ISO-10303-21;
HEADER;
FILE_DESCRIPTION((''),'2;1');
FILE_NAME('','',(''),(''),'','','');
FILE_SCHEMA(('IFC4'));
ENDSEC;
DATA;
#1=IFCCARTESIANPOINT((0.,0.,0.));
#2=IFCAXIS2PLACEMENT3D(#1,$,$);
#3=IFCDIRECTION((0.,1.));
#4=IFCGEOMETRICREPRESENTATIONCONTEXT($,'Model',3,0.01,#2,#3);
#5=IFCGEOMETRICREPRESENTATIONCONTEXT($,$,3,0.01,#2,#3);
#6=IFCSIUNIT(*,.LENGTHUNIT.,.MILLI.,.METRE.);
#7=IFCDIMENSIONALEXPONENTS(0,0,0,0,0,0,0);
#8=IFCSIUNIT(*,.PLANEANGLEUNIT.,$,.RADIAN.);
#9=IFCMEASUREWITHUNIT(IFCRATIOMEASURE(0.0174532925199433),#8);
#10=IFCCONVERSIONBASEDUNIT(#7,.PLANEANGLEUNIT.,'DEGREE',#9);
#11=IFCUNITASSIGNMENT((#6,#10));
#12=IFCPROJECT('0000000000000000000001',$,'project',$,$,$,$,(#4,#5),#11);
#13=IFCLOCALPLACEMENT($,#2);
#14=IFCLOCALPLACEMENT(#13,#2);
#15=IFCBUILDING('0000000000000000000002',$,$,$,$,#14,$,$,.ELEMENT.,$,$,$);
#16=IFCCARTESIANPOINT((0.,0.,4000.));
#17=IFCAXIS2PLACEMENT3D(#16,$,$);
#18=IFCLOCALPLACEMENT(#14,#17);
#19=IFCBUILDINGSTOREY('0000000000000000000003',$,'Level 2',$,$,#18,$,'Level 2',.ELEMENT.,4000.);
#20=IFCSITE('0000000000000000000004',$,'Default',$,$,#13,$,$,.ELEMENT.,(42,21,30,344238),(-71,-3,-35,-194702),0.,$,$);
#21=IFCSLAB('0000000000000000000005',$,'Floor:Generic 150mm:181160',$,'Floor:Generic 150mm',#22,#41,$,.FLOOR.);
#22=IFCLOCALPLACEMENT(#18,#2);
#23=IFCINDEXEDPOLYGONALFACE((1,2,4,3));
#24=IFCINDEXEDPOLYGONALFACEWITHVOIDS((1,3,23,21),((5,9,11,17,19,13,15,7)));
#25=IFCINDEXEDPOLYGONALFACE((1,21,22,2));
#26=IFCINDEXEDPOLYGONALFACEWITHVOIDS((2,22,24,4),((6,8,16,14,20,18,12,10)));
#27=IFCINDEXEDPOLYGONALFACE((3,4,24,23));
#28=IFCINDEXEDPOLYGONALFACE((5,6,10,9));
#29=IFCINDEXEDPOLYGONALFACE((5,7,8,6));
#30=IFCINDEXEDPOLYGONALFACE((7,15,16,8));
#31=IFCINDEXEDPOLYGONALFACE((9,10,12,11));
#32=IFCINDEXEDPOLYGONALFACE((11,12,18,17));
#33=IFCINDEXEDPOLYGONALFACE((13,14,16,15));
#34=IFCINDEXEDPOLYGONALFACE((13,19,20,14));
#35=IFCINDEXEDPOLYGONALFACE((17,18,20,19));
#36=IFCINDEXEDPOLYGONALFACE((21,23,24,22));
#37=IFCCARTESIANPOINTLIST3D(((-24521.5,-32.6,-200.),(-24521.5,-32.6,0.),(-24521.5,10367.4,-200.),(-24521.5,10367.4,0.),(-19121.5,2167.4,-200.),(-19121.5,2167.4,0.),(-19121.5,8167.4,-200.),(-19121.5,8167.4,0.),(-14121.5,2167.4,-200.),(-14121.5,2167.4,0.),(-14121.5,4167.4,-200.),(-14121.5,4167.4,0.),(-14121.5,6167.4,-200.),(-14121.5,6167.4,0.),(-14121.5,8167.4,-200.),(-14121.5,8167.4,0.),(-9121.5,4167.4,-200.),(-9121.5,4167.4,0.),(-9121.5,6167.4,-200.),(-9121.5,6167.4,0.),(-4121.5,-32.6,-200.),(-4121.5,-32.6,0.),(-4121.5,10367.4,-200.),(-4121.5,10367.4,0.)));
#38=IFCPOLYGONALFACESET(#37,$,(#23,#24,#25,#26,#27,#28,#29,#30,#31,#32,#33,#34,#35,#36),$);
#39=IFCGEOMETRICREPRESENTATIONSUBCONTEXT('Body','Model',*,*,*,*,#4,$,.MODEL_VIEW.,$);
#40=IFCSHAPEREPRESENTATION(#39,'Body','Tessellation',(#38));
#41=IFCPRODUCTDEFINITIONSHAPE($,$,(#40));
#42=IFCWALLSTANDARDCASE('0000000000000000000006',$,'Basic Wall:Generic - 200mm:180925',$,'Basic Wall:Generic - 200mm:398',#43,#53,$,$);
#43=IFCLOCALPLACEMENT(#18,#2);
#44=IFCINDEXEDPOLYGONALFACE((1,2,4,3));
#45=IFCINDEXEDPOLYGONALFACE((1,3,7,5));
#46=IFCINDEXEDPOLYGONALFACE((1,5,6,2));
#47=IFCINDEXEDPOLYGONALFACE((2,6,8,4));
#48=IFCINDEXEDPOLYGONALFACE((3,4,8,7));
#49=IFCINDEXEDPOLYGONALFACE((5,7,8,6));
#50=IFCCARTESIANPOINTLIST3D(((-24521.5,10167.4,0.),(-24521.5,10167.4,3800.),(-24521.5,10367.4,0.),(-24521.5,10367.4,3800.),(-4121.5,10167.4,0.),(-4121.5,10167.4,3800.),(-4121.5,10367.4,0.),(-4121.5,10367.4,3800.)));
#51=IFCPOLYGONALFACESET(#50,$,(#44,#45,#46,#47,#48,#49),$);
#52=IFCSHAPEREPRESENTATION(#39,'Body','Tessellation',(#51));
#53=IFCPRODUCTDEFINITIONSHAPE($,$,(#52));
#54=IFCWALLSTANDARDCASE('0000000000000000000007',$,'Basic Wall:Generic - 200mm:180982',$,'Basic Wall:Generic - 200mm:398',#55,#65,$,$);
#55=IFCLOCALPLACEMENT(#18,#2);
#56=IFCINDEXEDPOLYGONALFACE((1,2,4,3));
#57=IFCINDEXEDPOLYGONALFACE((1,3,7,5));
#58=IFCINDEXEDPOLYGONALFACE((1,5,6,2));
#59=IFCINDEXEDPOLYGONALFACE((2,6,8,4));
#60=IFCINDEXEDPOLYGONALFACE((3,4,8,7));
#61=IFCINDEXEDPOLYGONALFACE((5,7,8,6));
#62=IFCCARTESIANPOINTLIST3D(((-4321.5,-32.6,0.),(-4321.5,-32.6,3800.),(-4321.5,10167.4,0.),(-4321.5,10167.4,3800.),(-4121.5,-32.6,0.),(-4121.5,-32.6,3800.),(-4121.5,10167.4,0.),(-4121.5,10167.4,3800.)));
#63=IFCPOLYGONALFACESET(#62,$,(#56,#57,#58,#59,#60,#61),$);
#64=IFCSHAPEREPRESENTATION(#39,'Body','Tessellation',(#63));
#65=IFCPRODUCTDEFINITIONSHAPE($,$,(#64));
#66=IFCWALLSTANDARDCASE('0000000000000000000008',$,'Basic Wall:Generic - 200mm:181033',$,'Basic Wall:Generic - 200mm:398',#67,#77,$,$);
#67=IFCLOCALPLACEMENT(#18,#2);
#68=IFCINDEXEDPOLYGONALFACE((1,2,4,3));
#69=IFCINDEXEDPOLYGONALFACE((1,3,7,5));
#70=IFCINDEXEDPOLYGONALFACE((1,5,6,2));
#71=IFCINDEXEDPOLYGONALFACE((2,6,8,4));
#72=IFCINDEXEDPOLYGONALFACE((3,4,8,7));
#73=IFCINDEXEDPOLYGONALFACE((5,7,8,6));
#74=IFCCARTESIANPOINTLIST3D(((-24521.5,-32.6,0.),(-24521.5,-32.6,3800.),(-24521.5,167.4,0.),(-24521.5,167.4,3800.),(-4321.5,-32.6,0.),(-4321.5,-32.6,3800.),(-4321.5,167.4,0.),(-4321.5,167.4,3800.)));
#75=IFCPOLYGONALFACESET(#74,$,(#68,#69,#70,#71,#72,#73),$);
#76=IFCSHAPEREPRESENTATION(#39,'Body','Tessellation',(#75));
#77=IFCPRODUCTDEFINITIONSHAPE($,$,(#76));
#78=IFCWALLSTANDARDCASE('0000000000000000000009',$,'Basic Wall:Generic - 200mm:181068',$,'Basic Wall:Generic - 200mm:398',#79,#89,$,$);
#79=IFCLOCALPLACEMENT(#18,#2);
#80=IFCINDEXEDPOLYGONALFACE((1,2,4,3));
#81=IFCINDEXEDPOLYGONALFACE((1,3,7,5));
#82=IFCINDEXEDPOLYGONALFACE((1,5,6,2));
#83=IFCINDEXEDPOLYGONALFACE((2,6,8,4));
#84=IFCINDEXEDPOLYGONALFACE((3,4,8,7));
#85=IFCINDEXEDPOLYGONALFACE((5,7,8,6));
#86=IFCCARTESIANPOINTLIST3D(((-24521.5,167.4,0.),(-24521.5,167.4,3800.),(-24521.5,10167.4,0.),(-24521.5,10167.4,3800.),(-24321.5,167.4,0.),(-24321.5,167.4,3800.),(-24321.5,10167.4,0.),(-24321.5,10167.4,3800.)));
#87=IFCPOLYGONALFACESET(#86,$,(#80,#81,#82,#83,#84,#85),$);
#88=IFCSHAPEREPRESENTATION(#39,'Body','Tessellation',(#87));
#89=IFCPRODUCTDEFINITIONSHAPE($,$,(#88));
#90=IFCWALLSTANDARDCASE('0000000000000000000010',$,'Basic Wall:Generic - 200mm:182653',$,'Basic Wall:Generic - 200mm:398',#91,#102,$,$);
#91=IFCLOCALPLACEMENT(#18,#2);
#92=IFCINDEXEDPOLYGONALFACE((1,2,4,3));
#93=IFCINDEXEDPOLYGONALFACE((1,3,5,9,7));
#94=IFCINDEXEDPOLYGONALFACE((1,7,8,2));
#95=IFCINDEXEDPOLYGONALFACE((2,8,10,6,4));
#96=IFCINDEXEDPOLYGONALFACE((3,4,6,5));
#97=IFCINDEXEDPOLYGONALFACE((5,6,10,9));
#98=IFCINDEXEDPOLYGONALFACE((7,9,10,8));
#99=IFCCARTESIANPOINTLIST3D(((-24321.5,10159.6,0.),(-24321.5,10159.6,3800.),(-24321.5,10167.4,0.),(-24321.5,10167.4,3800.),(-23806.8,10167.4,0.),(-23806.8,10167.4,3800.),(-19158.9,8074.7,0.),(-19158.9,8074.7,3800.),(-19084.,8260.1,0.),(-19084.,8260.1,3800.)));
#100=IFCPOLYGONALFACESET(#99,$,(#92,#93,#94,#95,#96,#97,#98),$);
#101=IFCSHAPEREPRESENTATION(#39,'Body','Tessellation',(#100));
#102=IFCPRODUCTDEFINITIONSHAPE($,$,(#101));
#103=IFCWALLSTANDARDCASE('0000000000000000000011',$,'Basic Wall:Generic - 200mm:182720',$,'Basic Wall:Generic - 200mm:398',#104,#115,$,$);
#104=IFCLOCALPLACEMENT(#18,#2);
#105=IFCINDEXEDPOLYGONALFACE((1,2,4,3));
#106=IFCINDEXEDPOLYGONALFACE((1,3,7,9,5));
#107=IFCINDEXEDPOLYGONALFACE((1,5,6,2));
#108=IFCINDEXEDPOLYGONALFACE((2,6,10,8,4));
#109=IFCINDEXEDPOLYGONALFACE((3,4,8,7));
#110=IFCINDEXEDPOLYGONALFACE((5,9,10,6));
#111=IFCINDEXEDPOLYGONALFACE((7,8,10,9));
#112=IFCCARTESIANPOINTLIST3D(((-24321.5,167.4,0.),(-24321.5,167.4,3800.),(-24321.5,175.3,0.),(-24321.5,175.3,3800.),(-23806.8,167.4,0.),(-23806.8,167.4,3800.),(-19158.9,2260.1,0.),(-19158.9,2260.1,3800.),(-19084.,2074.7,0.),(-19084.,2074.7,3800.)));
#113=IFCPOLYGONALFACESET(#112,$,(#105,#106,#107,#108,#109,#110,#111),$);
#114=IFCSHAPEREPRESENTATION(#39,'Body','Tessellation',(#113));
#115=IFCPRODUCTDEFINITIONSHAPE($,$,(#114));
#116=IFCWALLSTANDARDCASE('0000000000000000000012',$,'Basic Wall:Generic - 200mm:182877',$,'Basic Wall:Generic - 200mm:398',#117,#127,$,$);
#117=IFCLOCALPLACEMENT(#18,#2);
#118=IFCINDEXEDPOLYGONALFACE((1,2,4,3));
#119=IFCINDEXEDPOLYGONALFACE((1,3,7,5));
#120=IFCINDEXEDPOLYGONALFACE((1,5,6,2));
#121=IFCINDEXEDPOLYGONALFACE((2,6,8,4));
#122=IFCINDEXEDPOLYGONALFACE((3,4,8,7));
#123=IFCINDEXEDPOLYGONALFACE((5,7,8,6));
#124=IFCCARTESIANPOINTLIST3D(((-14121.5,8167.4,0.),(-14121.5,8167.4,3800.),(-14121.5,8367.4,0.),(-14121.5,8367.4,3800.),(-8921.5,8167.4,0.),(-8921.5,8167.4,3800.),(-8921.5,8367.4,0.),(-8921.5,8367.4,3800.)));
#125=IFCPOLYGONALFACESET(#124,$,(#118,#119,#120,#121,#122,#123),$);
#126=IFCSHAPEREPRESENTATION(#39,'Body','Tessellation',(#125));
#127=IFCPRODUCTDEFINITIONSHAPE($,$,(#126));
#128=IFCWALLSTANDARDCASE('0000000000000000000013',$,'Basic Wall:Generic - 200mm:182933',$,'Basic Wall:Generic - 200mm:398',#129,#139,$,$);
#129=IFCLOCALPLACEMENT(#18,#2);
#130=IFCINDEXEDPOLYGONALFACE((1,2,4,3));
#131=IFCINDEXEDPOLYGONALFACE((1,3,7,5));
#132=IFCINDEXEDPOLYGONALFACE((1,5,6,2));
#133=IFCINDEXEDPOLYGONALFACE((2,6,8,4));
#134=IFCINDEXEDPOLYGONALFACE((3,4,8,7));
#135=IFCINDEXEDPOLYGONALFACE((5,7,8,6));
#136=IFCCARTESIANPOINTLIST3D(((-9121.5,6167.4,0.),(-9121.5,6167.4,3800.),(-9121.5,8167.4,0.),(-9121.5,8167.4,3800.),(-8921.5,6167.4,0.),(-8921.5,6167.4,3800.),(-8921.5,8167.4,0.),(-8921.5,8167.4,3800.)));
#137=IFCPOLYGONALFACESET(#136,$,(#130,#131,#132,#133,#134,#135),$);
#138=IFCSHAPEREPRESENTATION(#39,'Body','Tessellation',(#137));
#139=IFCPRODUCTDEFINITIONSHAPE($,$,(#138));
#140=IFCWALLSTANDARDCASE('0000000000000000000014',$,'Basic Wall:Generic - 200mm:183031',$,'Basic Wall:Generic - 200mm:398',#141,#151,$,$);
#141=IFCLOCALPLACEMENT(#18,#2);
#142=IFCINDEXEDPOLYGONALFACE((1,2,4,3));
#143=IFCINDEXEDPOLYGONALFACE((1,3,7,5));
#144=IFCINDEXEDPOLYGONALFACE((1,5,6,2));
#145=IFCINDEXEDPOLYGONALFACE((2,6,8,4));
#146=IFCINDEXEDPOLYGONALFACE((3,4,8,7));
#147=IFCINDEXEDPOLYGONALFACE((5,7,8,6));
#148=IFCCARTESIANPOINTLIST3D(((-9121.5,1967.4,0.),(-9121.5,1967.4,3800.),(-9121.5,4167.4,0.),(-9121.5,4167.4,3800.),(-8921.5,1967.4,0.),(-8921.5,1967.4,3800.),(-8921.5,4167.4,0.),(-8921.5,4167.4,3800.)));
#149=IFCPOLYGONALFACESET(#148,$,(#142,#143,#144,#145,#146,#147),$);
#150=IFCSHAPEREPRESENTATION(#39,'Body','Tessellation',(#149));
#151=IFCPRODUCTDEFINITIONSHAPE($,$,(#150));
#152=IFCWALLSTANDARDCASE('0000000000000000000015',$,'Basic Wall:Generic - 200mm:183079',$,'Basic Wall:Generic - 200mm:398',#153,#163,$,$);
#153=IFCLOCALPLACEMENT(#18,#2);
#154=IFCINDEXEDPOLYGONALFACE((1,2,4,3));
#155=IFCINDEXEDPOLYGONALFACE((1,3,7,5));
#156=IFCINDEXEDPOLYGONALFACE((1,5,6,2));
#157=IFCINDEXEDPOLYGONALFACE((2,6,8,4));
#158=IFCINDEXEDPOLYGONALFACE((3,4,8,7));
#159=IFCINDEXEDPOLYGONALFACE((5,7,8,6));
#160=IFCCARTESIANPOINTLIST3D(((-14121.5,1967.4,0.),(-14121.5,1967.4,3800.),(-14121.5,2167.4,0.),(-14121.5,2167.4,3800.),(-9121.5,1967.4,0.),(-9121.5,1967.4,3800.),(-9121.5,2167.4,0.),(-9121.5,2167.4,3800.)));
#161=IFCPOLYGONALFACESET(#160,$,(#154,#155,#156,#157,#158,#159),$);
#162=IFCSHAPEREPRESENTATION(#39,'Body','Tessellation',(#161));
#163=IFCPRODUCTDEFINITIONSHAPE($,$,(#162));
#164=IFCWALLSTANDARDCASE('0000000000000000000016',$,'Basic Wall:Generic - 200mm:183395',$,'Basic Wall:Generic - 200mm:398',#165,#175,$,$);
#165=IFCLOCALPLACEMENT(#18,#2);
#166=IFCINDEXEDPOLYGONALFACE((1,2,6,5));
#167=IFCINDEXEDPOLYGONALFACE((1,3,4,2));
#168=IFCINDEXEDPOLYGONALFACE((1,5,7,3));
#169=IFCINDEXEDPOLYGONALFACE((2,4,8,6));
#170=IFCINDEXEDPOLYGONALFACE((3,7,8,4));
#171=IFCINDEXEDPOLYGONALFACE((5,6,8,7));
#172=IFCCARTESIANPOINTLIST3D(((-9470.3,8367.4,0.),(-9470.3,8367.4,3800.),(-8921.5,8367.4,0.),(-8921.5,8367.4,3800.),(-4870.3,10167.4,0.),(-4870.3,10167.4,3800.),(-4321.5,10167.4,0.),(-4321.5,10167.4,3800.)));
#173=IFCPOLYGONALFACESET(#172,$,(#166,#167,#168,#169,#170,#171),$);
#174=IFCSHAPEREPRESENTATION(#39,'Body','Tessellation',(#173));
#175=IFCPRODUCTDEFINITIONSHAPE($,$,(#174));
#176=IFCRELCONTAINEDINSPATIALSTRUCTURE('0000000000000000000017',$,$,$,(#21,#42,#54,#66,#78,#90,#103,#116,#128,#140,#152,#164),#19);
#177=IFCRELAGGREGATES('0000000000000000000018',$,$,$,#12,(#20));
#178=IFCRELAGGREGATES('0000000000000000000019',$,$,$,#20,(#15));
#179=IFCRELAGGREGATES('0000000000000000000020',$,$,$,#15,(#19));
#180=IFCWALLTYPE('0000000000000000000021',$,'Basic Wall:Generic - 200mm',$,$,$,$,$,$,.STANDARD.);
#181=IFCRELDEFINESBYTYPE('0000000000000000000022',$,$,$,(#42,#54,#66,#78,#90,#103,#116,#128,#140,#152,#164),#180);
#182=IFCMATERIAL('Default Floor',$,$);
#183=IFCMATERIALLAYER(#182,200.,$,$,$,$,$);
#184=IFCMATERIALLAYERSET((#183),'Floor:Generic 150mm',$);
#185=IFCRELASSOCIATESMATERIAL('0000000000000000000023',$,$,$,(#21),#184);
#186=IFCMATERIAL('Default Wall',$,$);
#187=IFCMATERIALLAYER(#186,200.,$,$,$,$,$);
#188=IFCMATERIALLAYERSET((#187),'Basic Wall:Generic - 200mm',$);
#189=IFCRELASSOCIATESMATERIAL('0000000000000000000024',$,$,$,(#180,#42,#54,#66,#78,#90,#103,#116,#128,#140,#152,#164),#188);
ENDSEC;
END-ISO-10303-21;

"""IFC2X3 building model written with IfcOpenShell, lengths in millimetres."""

from ifc_helpers import new_model, entity, si_unit, converted_unit, direction, frame, frame_2d, origin, place, context, subcontext, project, spatial, polyline, rectangle, outline, extrude, material, layer, layer_set, layer_usage, type_object, element, save


model = new_model("IFC2X3")

# Units and contexts
model_context = context("Model", 3, precision=0.01, world=origin(), true_north=direction((0.0, 1.0)))
context_of_model = context(None, 3, precision=0.01, world=origin(), true_north=direction((0.0, 1.0)))
body_context = subcontext(model_context, "Body", "Model", "MODEL_VIEW")
ifc_project = project(units=[si_unit("LENGTHUNIT", "METRE", prefix="MILLI"), converted_unit("PLANEANGLEUNIT", "DEGREE", entity("IfcRatioMeasure", 0.0174532925199433), si_unit("PLANEANGLEUNIT", "RADIAN"), dimensions=[0, 0, 0, 0, 0, 0, 0])], contexts=[model_context, context_of_model])

# Site, building, storey
site_placement = place(None, origin())
site = spatial("IfcSite", under=ifc_project, at=site_placement, Name="Default", CompositionType="ELEMENT", RefLatitude=(42, 21, 30, 344238), RefLongitude=(-71, -3, -35, -194702), RefElevation=0.0)
building_placement = place(site_placement, origin())
building = spatial("IfcBuilding", under=site, at=building_placement, CompositionType="ELEMENT")
storey_placement = place(building_placement, frame((0.0, 0.0, 4000.0)))
storey = spatial("IfcBuildingStorey", under=building, at=storey_placement, Name="Level 2", LongName="Level 2", CompositionType="ELEMENT", Elevation=4000.0)

# Slab, opening
ifc_material_1 = material(Name="Default Floor")
ifc_layer_1 = layer(ifc_material_1, 200.0)
ifc_layer_set_1 = layer_set([ifc_layer_1], Name="Floor:Generic 150mm")
ifc_layer_usage_1 = layer_usage(ifc_layer_set_1, "AXIS3", "POSITIVE", 0.0)
slab_placement = place(storey_placement, frame((-24521.5, -32.6, -200.0)))
slab = element("IfcSlab", 1, at=slab_placement, inside=storey, material=ifc_layer_usage_1, Name="Floor:Generic 150mm:181160", ObjectType="Floor:Generic 150mm", PredefinedType="FLOOR", context=body_context, shape_type="SweptSolid", body=[
    extrude(rectangle(XDim=10400.0, YDim=20400.0, at=frame_2d((0.0, 0.0), x_axis=(0.0, -1.0))), frame((10200.0, 5200.0, 200.0), z_axis=(0.0, 0.0, -1.0), x_axis=(-1.0, 0.0, 0.0)), (0.0, 0.0, 1.0), 200.0),
])
opening_placement = place(slab_placement, frame((10400.0, 5200.0, 200.0)))
element("IfcOpeningElement", 2, at=opening_placement, cuts=slab, ObjectType="Opening", context=body_context, shape_type="SweptSolid", body=[
    extrude(outline(polyline([(-5000.0, 3000.0), (-5000.0, -3000.0), (0.0, -3000.0), (0.0, -1000.0), (5000.0, -1000.0), (5000.0, 1000.0), (0.0, 1000.0), (0.0, 3000.0), (-5000.0, 3000.0)])), origin(), (0.0, 0.0, -1.0), 200.0),
])

# Walls
ifc_material_2 = material(Name="Default Wall")
ifc_layer_2 = layer(ifc_material_2, 200.0)
ifc_layer_set_2 = layer_set([ifc_layer_2], Name="Basic Wall:Generic - 200mm")
ifc_layer_usage_2 = layer_usage(ifc_layer_set_2, "AXIS2", "NEGATIVE", 100.0)
wall_type = type_object("IfcWallType", Name="Basic Wall:Generic - 200mm", PredefinedType="STANDARD", material=ifc_layer_set_2)
wall_1_placement = place(storey_placement, frame((-24521.5, 10267.4, 0.0)))
element("IfcWallStandardCase", 3, at=wall_1_placement, inside=storey, type_object=wall_type, material=ifc_layer_usage_2, Name="Basic Wall:Generic - 200mm:180925", ObjectType="Basic Wall:Generic - 200mm:398", context=body_context, shape_type="SweptSolid", body=[
    extrude(rectangle(XDim=20400.0, YDim=200.0, at=frame_2d((10200.0, 0.0), x_axis=(-1.0, 0.0))), origin(), (0.0, 0.0, 1.0), 3800.0),
])
ifc_layer_usage_3 = layer_usage(ifc_layer_set_2, "AXIS2", "NEGATIVE", 100.0)
wall_2_placement = place(storey_placement, frame((-4221.5, 10167.4, 0.0), z_axis=(0.0, 0.0, 1.0), x_axis=(0.0, -1.0, 0.0)))
element("IfcWallStandardCase", 4, at=wall_2_placement, inside=storey, type_object=wall_type, material=ifc_layer_usage_3, Name="Basic Wall:Generic - 200mm:180982", ObjectType="Basic Wall:Generic - 200mm:398", context=body_context, shape_type="SweptSolid", body=[
    extrude(rectangle(XDim=10200.0, YDim=200.0, at=frame_2d((5100.0, 0.0), x_axis=(-1.0, 0.0))), origin(), (0.0, 0.0, 1.0), 3800.0),
])
ifc_layer_usage_4 = layer_usage(ifc_layer_set_2, "AXIS2", "NEGATIVE", 100.0)
wall_3_placement = place(storey_placement, frame((-4321.5, 67.4, 0.0), z_axis=(0.0, 0.0, 1.0), x_axis=(-1.0, 0.0, 0.0)))
element("IfcWallStandardCase", 5, at=wall_3_placement, inside=storey, type_object=wall_type, material=ifc_layer_usage_4, Name="Basic Wall:Generic - 200mm:181033", ObjectType="Basic Wall:Generic - 200mm:398", context=body_context, shape_type="SweptSolid", body=[
    extrude(rectangle(XDim=20200.0, YDim=200.0, at=frame_2d((10100.0, 0.0), x_axis=(-1.0, 0.0))), origin(), (0.0, 0.0, 1.0), 3800.0),
])
ifc_layer_usage_5 = layer_usage(ifc_layer_set_2, "AXIS2", "NEGATIVE", 100.0)
wall_4_placement = place(storey_placement, frame((-24421.5, 167.4, 0.0), z_axis=(0.0, 0.0, 1.0), x_axis=(0.0, 1.0, 0.0)))
element("IfcWallStandardCase", 6, at=wall_4_placement, inside=storey, type_object=wall_type, material=ifc_layer_usage_5, Name="Basic Wall:Generic - 200mm:181068", ObjectType="Basic Wall:Generic - 200mm:398", context=body_context, shape_type="SweptSolid", body=[
    extrude(rectangle(XDim=10000.0, YDim=200.0, at=frame_2d((5000.0, 0.0), x_axis=(-1.0, 0.0))), origin(), (0.0, 0.0, 1.0), 3800.0),
])
ifc_layer_usage_6 = layer_usage(ifc_layer_set_2, "AXIS2", "NEGATIVE", 100.0)
wall_5_placement = place(storey_placement, frame((-19121.5, 8167.4, 0.0), z_axis=(0.0, 0.0, 1.0), x_axis=(-0.927242, 0.374463, 0.0)))
element("IfcWallStandardCase", 7, at=wall_5_placement, inside=storey, type_object=wall_type, material=ifc_layer_usage_6, Name="Basic Wall:Generic - 200mm:182653", ObjectType="Basic Wall:Generic - 200mm:398", context=body_context, shape_type="SweptSolid", body=[
    extrude(outline(polyline([(5093.4, -100.0), (5570.6, 92.7), (5567.6, 100.0), (0.0, 100.0), (0.0, -100.0), (5093.4, -100.0)])), origin(), (0.0, 0.0, 1.0), 3800.0),
])
ifc_layer_usage_7 = layer_usage(ifc_layer_set_2, "AXIS2", "NEGATIVE", 100.0)
wall_6_placement = place(storey_placement, frame((-19121.5, 2167.4, 0.0), z_axis=(0.0, 0.0, 1.0), x_axis=(-0.927242, -0.374463, 0.0)))
element("IfcWallStandardCase", 8, at=wall_6_placement, inside=storey, type_object=wall_type, material=ifc_layer_usage_7, Name="Basic Wall:Generic - 200mm:182720", ObjectType="Basic Wall:Generic - 200mm:398", context=body_context, shape_type="SweptSolid", body=[
    extrude(outline(polyline([(5567.6, -100.0), (5570.6, -92.7), (5093.4, 100.0), (0.0, 100.0), (0.0, -100.0), (5567.6, -100.0)])), origin(), (0.0, 0.0, 1.0), 3800.0),
])
ifc_layer_usage_8 = layer_usage(ifc_layer_set_2, "AXIS2", "NEGATIVE", 100.0)
wall_7_placement = place(storey_placement, frame((-14121.5, 8267.4, 0.0)))
element("IfcWallStandardCase", 9, at=wall_7_placement, inside=storey, type_object=wall_type, material=ifc_layer_usage_8, Name="Basic Wall:Generic - 200mm:182877", ObjectType="Basic Wall:Generic - 200mm:398", context=body_context, shape_type="SweptSolid", body=[
    extrude(rectangle(XDim=5200.0, YDim=200.0, at=frame_2d((2600.0, 0.0), x_axis=(-1.0, 0.0))), origin(), (0.0, 0.0, 1.0), 3800.0),
])
ifc_layer_usage_9 = layer_usage(ifc_layer_set_2, "AXIS2", "NEGATIVE", 100.0)
wall_8_placement = place(storey_placement, frame((-9021.5, 8167.4, 0.0), z_axis=(0.0, 0.0, 1.0), x_axis=(0.0, -1.0, 0.0)))
element("IfcWallStandardCase", 10, at=wall_8_placement, inside=storey, type_object=wall_type, material=ifc_layer_usage_9, Name="Basic Wall:Generic - 200mm:182933", ObjectType="Basic Wall:Generic - 200mm:398", context=body_context, shape_type="SweptSolid", body=[
    extrude(rectangle(XDim=2000.0, YDim=200.0, at=frame_2d((1000.0, 0.0), x_axis=(-1.0, 0.0))), origin(), (0.0, 0.0, 1.0), 3800.0),
])
ifc_layer_usage_10 = layer_usage(ifc_layer_set_2, "AXIS2", "NEGATIVE", 100.0)
wall_9_placement = place(storey_placement, frame((-9021.5, 4167.4, 0.0), z_axis=(0.0, 0.0, 1.0), x_axis=(0.0, -1.0, 0.0)))
element("IfcWallStandardCase", 11, at=wall_9_placement, inside=storey, type_object=wall_type, material=ifc_layer_usage_10, Name="Basic Wall:Generic - 200mm:183031", ObjectType="Basic Wall:Generic - 200mm:398", context=body_context, shape_type="SweptSolid", body=[
    extrude(rectangle(XDim=2200.0, YDim=200.0, at=frame_2d((1100.0, 0.0), x_axis=(-1.0, 0.0))), origin(), (0.0, 0.0, 1.0), 3800.0),
])
ifc_layer_usage_11 = layer_usage(ifc_layer_set_2, "AXIS2", "NEGATIVE", 100.0)
wall_10_placement = place(storey_placement, frame((-9121.5, 2067.4, 0.0), z_axis=(0.0, 0.0, 1.0), x_axis=(-1.0, 0.0, 0.0)))
element("IfcWallStandardCase", 12, at=wall_10_placement, inside=storey, type_object=wall_type, material=ifc_layer_usage_11, Name="Basic Wall:Generic - 200mm:183079", ObjectType="Basic Wall:Generic - 200mm:398", context=body_context, shape_type="SweptSolid", body=[
    extrude(rectangle(XDim=5000.0, YDim=200.0, at=frame_2d((2500.0, 0.0), x_axis=(-1.0, 0.0))), origin(), (0.0, 0.0, 1.0), 3800.0),
])
ifc_layer_usage_12 = layer_usage(ifc_layer_set_2, "AXIS2", "NEGATIVE", 100.0)
wall_11_placement = place(storey_placement, frame((-9433.9, 8274.3, 0.0), z_axis=(0.0, 0.0, 1.0), x_axis=(0.931243, 0.364399, 0.0)))
element("IfcWallStandardCase", 13, at=wall_11_placement, inside=storey, type_object=wall_type, material=ifc_layer_usage_12, Name="Basic Wall:Generic - 200mm:183395", ObjectType="Basic Wall:Generic - 200mm:398", context=body_context, shape_type="SweptSolid", body=[
    extrude(outline(polyline([(5450.7, -100.0), (4939.6, 100.0), (0.0, 100.0), (511.1, -100.0), (5450.7, -100.0)])), origin(), (0.0, 0.0, 1.0), 3800.0),
])

save(model, "model.ifc")
